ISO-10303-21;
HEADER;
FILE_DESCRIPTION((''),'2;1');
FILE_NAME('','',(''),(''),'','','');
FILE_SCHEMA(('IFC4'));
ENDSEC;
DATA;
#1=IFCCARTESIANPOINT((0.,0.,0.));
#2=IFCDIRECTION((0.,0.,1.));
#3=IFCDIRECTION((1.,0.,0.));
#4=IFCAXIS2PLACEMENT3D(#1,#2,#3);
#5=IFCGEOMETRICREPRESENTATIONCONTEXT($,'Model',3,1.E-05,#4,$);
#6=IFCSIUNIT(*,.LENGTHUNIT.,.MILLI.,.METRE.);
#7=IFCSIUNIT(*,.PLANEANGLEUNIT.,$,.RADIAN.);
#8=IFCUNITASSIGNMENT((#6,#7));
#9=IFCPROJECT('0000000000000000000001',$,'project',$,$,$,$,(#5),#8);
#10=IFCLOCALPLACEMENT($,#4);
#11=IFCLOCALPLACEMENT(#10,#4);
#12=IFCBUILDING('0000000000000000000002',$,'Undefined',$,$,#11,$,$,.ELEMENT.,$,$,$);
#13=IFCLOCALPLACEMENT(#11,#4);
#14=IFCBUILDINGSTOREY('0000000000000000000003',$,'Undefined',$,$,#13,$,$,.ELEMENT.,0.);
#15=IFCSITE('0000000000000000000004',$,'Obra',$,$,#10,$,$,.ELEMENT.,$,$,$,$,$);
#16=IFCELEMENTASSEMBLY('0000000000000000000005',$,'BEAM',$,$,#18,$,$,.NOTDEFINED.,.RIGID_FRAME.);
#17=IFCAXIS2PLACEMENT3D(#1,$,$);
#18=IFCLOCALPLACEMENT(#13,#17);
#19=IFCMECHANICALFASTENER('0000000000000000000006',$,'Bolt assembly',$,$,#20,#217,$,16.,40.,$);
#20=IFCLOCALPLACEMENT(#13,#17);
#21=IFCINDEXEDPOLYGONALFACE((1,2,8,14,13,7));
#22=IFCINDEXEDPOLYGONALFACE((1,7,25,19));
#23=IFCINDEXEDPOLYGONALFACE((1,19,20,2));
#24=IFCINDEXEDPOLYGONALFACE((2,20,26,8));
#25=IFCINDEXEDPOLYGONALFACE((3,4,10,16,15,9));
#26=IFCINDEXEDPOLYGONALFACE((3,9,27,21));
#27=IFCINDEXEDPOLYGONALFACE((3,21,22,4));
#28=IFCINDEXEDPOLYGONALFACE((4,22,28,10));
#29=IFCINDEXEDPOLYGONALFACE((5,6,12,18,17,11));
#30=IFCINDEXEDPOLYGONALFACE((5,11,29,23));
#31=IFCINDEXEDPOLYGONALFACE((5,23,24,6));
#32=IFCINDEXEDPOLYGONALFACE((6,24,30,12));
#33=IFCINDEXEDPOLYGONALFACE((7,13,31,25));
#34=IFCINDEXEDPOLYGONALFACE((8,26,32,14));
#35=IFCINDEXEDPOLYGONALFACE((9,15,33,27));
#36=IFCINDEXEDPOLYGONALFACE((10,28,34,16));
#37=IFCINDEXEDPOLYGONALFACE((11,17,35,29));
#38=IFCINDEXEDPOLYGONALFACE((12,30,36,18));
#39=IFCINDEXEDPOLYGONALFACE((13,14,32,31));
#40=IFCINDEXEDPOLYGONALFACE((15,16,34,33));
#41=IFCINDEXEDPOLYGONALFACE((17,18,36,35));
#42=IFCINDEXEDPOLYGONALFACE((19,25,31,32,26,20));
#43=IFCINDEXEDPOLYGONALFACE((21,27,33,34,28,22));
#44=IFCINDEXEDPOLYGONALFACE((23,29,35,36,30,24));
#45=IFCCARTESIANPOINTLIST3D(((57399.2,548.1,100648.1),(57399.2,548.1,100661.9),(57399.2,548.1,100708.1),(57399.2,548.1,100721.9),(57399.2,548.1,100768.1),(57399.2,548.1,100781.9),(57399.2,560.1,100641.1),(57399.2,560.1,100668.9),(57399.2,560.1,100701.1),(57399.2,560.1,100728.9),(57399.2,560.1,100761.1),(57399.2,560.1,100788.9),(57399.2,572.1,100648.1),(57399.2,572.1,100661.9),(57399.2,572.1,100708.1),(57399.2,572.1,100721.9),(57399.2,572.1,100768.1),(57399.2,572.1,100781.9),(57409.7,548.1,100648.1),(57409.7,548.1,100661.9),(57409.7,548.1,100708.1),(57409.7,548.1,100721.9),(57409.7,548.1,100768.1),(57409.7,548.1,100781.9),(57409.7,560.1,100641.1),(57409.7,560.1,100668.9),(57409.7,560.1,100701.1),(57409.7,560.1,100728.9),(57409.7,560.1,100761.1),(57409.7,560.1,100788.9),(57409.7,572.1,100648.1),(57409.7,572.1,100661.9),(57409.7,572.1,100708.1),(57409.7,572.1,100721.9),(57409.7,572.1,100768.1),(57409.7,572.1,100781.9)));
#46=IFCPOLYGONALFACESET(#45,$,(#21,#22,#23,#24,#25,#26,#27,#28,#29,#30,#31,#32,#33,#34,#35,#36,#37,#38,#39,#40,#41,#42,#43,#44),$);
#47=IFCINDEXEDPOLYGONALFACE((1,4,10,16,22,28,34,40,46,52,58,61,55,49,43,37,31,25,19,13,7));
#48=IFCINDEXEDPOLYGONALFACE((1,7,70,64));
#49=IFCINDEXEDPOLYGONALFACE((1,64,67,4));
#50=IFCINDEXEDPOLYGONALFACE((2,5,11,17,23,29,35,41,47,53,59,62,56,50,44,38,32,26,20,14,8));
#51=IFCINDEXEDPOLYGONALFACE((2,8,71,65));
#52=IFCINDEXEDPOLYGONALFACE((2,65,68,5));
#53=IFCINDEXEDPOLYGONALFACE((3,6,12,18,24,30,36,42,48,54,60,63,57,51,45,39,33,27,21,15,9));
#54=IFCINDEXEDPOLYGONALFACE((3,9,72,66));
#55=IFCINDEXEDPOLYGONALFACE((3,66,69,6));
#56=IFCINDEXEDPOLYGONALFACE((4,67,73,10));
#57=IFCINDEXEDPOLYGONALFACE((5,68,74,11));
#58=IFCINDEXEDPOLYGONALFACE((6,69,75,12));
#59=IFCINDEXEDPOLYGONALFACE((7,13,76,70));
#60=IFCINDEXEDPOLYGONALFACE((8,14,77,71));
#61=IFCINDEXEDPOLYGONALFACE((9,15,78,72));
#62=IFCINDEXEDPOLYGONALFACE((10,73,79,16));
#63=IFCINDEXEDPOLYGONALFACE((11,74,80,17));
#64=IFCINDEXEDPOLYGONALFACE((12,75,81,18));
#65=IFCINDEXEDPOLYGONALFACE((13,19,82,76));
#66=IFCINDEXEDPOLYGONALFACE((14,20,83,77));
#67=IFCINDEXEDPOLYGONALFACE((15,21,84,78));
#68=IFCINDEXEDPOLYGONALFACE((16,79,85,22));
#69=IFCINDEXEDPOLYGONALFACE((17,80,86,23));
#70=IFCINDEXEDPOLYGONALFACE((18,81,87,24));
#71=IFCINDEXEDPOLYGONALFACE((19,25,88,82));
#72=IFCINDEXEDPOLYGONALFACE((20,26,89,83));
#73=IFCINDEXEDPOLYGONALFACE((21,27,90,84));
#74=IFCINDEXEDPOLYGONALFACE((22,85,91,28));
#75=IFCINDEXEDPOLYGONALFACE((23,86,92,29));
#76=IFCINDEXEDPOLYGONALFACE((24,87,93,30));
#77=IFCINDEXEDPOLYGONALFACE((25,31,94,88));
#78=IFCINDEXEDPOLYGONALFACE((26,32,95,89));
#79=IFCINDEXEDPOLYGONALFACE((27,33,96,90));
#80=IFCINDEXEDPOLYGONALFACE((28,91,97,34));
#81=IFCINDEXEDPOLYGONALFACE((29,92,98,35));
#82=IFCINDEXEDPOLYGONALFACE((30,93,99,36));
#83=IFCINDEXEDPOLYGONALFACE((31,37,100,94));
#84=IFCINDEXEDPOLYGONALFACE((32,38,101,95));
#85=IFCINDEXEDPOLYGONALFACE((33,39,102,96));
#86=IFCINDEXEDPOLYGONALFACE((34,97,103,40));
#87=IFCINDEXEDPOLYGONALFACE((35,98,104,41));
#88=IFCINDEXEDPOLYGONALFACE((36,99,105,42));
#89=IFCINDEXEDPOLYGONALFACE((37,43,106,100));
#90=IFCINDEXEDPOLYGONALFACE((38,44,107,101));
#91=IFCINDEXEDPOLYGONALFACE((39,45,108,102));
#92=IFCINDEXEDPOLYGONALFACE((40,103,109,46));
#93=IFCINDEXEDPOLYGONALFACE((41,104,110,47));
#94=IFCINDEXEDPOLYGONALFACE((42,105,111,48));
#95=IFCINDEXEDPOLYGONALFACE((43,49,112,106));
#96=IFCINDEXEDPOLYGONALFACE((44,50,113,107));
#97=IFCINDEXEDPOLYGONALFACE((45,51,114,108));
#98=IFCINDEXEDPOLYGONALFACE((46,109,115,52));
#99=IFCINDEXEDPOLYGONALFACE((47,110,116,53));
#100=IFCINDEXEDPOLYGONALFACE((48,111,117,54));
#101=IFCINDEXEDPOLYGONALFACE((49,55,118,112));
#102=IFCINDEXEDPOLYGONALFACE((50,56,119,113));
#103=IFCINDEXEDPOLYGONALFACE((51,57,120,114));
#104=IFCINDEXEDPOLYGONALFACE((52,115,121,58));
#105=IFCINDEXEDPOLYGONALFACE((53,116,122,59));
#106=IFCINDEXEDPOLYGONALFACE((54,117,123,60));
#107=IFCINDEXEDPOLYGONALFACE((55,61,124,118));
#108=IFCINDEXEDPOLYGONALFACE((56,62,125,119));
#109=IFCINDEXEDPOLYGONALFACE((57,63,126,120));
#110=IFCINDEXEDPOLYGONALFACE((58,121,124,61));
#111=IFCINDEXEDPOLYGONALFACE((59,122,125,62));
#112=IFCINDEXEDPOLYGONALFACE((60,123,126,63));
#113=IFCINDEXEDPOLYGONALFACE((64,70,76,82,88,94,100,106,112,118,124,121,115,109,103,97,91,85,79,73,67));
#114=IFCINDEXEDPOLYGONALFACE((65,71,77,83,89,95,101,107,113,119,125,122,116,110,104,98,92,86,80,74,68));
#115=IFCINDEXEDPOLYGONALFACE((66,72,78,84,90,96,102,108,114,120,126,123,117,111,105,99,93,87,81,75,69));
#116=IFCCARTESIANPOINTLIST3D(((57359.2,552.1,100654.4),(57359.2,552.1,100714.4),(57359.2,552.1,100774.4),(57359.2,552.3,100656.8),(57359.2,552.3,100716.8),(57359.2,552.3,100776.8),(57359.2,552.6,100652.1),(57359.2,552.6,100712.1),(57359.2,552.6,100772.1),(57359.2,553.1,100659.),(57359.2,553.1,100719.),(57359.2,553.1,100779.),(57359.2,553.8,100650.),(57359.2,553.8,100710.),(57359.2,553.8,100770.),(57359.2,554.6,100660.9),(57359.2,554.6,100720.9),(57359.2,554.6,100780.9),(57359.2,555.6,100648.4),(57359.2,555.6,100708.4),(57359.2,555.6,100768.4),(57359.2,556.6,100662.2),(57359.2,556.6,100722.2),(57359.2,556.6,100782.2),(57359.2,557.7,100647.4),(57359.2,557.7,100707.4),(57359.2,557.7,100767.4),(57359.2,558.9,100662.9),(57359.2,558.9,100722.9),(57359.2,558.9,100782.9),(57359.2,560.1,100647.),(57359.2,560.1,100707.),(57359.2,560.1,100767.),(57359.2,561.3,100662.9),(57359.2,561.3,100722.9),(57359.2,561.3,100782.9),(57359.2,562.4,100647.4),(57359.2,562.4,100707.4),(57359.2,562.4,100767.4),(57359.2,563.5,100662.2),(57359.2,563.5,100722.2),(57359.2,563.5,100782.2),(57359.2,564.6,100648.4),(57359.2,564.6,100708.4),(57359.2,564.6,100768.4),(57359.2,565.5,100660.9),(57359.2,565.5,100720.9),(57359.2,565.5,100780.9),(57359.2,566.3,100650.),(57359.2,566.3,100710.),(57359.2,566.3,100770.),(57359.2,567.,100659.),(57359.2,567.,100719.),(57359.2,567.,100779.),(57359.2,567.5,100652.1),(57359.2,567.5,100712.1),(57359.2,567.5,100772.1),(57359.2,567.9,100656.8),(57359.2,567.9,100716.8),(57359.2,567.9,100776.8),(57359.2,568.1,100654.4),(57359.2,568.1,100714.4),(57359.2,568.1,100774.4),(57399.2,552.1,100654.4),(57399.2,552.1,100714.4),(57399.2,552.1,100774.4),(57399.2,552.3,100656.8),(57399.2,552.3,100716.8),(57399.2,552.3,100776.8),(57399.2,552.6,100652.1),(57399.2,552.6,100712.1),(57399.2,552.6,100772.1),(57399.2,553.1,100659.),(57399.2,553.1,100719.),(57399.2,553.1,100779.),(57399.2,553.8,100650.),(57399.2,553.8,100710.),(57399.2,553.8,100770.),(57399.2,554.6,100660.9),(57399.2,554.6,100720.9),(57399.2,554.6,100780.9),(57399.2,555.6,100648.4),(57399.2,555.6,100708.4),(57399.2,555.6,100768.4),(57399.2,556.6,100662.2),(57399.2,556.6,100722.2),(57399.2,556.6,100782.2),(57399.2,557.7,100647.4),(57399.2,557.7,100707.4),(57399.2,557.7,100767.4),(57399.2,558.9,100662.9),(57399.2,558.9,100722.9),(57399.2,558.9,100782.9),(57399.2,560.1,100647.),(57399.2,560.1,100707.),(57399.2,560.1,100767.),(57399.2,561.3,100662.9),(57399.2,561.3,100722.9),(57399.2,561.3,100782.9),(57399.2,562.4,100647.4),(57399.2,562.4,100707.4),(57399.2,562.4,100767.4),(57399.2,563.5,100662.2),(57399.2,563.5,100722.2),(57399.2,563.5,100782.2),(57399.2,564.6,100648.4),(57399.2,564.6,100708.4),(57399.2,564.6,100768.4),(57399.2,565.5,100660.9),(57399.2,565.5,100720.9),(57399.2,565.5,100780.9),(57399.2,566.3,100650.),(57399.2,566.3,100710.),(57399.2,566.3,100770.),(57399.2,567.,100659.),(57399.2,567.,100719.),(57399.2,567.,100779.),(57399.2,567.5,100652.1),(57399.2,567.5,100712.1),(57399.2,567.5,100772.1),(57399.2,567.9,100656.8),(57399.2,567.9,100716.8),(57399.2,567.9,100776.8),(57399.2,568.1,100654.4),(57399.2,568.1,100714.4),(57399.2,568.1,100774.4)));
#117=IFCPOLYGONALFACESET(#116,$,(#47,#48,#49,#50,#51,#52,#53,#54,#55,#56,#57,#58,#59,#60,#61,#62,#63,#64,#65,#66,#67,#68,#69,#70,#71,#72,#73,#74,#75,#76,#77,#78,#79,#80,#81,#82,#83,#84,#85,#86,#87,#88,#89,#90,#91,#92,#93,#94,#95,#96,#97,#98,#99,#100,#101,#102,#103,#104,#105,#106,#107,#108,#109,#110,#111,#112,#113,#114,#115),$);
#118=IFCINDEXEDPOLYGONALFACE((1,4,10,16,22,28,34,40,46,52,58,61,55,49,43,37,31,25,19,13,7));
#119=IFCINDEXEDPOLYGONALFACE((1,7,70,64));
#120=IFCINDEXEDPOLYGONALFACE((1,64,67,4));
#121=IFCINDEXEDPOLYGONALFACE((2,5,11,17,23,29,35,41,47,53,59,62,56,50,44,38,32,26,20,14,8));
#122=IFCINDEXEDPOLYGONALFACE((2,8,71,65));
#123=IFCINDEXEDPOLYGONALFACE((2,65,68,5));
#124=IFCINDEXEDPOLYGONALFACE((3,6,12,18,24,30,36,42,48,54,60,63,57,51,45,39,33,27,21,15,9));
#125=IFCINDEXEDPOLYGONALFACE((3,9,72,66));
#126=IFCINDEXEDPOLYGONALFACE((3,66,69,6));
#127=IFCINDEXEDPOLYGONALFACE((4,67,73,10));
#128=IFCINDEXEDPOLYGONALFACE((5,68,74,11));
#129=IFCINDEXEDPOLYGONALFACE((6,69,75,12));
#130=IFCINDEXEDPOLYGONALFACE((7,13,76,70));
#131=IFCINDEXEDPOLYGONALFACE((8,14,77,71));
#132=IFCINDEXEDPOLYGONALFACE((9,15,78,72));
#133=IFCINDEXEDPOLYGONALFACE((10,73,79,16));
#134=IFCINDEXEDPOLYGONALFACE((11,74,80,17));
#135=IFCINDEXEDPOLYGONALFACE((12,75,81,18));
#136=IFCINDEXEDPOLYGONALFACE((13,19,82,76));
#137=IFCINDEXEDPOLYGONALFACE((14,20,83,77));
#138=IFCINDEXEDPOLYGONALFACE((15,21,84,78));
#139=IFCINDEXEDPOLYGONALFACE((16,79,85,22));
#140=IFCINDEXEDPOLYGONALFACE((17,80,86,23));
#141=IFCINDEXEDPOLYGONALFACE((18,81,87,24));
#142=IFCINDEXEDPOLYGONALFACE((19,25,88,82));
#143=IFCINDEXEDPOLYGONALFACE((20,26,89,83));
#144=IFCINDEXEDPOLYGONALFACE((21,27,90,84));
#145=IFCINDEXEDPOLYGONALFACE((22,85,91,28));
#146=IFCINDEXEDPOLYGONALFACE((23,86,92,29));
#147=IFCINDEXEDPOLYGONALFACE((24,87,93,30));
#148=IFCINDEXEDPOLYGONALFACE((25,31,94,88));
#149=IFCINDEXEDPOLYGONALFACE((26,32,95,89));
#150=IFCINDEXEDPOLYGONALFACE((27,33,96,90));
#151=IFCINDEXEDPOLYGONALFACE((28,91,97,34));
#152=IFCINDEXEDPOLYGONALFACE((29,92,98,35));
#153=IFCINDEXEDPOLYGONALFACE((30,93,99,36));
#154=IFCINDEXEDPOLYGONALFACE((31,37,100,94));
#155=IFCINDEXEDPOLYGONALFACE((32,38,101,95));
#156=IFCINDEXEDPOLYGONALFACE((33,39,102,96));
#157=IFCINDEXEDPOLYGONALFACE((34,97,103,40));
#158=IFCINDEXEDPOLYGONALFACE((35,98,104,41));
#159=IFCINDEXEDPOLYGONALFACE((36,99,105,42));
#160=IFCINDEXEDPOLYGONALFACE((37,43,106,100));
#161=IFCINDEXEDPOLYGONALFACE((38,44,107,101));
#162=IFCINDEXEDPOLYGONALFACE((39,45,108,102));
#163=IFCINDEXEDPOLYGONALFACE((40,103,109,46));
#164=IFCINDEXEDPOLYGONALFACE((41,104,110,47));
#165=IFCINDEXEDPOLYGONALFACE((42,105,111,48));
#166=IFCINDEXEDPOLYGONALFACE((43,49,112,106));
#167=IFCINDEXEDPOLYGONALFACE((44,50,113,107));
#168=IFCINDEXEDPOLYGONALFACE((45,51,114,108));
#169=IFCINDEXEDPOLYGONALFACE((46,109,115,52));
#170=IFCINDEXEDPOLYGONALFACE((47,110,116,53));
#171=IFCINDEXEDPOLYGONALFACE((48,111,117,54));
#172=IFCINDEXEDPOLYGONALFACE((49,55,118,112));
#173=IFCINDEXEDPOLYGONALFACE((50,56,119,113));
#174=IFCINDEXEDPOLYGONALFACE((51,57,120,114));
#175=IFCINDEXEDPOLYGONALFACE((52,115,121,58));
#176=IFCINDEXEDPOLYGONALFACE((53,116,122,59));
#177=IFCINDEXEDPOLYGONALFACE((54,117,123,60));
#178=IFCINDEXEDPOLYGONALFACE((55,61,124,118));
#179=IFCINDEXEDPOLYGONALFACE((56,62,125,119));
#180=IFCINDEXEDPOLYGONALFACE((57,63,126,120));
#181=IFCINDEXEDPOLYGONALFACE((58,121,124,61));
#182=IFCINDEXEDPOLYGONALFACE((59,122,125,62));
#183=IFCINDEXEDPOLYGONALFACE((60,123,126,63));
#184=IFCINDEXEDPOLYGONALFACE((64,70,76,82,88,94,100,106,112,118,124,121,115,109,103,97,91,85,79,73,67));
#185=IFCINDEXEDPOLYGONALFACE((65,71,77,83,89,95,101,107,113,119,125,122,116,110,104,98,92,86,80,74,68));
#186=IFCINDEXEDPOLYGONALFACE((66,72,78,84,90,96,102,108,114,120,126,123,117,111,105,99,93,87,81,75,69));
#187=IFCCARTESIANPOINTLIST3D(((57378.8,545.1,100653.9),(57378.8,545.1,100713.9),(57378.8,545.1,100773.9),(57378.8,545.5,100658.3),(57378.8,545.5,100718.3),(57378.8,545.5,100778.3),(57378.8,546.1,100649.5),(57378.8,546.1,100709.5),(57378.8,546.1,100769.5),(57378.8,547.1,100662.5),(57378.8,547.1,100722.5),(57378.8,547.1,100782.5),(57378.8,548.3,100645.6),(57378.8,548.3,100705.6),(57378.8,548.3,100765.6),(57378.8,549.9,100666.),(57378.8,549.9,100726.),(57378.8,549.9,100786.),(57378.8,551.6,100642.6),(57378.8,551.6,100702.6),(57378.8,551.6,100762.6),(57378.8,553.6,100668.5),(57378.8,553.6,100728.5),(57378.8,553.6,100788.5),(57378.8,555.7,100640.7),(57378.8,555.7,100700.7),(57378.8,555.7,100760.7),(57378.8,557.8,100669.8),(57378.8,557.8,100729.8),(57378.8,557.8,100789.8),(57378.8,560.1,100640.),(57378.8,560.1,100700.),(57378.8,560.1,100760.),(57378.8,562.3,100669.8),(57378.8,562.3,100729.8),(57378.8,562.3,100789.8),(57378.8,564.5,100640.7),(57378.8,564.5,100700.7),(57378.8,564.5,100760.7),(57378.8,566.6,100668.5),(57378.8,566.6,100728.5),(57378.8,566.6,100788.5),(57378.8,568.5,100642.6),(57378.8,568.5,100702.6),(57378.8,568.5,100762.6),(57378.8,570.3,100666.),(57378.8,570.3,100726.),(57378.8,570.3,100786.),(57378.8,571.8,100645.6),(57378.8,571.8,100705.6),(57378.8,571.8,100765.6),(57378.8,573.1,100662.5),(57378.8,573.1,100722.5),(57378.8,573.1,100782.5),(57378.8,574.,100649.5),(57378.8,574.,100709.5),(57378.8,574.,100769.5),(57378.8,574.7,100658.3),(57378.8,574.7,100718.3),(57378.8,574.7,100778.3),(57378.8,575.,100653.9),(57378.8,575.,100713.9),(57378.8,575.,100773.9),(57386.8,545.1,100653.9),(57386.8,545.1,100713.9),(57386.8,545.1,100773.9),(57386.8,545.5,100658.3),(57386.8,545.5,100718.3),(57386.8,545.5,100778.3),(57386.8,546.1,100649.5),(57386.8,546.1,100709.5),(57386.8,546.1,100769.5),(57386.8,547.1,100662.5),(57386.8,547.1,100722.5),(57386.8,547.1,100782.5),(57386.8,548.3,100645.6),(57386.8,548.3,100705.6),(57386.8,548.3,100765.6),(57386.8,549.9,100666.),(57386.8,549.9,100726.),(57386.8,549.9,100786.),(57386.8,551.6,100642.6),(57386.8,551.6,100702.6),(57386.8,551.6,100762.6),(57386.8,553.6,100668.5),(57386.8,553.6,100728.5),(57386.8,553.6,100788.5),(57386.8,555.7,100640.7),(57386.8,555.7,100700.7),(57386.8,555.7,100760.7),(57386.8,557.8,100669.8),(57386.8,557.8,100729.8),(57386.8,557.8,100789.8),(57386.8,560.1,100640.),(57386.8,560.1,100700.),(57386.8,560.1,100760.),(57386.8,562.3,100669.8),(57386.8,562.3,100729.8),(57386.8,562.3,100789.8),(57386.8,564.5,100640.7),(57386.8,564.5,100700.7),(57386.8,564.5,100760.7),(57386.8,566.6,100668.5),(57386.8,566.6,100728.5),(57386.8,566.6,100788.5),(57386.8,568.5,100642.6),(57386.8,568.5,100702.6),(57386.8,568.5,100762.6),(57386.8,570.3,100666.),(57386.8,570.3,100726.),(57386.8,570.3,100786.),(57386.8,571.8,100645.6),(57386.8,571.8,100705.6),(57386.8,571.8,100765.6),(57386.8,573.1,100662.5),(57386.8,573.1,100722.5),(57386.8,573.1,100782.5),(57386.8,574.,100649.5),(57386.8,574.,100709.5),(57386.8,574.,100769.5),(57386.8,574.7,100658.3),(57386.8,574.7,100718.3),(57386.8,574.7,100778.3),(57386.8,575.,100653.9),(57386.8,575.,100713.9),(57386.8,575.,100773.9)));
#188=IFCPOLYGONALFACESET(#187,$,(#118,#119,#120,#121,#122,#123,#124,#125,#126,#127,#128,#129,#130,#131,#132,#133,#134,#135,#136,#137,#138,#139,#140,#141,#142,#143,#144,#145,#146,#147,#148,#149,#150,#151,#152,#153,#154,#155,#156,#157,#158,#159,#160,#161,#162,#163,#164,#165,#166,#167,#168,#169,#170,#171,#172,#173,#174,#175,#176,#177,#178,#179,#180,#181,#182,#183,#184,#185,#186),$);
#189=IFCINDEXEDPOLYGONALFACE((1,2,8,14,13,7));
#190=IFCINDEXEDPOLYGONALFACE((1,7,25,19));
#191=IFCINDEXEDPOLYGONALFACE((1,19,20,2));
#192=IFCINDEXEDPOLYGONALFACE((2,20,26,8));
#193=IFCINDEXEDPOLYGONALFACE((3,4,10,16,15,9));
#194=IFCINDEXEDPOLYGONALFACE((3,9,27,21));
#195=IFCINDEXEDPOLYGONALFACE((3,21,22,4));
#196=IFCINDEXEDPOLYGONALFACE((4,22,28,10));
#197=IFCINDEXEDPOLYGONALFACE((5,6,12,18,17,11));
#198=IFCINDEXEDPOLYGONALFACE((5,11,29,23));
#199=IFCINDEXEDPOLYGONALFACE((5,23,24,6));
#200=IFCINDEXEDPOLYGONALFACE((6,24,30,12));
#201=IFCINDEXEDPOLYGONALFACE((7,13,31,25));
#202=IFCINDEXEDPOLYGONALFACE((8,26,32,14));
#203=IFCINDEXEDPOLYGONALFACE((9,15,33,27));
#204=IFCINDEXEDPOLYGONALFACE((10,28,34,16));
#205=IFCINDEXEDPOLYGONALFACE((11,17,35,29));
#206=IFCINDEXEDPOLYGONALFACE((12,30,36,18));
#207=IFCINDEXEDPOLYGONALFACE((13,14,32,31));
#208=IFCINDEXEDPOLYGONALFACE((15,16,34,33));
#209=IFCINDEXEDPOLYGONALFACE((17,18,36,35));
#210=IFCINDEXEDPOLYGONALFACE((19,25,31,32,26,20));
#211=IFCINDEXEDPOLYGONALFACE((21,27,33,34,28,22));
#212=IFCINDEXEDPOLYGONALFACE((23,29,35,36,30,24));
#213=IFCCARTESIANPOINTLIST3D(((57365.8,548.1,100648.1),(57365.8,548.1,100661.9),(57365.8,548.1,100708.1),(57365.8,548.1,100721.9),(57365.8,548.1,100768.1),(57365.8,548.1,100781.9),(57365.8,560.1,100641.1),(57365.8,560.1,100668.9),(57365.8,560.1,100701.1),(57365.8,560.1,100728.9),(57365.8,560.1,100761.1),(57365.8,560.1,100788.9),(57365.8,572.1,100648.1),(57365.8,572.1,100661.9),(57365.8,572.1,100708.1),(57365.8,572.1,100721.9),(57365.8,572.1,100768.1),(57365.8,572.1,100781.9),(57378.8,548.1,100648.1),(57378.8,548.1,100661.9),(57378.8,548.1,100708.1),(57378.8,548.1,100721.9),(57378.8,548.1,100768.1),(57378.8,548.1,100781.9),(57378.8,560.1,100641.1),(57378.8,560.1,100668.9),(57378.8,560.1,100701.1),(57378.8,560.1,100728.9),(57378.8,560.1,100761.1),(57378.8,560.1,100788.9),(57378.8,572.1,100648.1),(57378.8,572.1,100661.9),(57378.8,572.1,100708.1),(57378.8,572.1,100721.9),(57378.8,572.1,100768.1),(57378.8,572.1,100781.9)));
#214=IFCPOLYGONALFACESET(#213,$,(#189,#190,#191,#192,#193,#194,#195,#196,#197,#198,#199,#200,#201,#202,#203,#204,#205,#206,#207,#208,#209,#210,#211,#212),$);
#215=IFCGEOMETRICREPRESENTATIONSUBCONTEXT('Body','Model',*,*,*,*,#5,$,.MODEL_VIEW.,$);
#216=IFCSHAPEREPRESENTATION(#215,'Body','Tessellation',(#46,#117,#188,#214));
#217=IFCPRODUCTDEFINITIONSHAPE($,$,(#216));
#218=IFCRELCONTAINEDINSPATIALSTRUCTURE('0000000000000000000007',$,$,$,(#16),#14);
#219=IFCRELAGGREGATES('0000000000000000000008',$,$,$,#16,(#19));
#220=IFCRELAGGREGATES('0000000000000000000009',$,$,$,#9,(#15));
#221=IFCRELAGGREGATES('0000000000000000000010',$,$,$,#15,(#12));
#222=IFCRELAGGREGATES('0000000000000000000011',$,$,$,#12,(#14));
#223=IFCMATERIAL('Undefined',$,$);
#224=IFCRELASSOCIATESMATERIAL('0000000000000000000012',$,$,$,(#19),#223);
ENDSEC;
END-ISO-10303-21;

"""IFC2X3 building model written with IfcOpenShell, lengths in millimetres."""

from ifc_helpers import new_model, si_unit, frame, origin_with_axes, origin_2d_with_axis, place, context, subcontext, project, spatial, polyline, circle, outline, extrude, source, transform, mapped, material, element, aggregate, save


model = new_model("IFC2X3")

# Units and contexts
model_context = context("Model", 3, precision=1e-05, world=origin_with_axes())
body_context = subcontext(model_context, "Body", "Model", "MODEL_VIEW")
ifc_project = project(units=[si_unit("LENGTHUNIT", "METRE", prefix="MILLI"), si_unit("PLANEANGLEUNIT", "RADIAN")], contexts=[model_context])

# Site, building, storey
site_placement = place(None, origin_with_axes())
site = spatial("IfcSite", under=ifc_project, at=site_placement, Name="Obra", CompositionType="ELEMENT")
building_placement = place(site_placement, origin_with_axes())
building = spatial("IfcBuilding", under=site, at=building_placement, Name="Undefined", CompositionType="ELEMENT")
storey_placement = place(building_placement, origin_with_axes())
storey = spatial("IfcBuildingStorey", under=building, at=storey_placement, Name="Undefined", CompositionType="ELEMENT", Elevation=0.0)

# Shared definitions
ifc_material_1 = material(Name="Undefined")

# Element assembly, mechanical fastener
shared_shape_1 = source(origin_with_axes(), body_context, "Body", "SweptSolid", [
    extrude(outline(polyline([(13.9, 0.0), (6.9, 12.0), (-6.9, 12.0), (-13.9, 0.0), (-6.9, -12.0), (6.9, -12.0), (13.9, 0.0)])), frame((0.0, -19.7, 0.0), z_axis=(0.0, 1.0, 0.0), x_axis=(1.0, 0.0, 0.0)), (0.0, 0.0, 1.0), 10.6),
    extrude(circle(Radius=8.0, at=origin_2d_with_axis()), frame((0.0, -9.1, 0.0), z_axis=(0.0, 1.0, 0.0), x_axis=(1.0, 0.0, 0.0)), (0.0, 0.0, 1.0), 40.0),
    extrude(circle(Radius=15.0, at=origin_2d_with_axis()), frame((0.0, 3.3, 0.0), z_axis=(0.0, 1.0, 0.0), x_axis=(1.0, 0.0, 0.0)), (0.0, 0.0, 1.0), 8.0),
    extrude(outline(polyline([(13.9, 0.0), (6.9, 12.0), (-6.9, 12.0), (-13.9, 0.0), (-6.9, -12.0), (6.9, -12.0), (13.9, 0.0)])), frame((0.0, 11.3, 0.0), z_axis=(0.0, 1.0, 0.0), x_axis=(1.0, 0.0, 0.0)), (0.0, 0.0, 1.0), 13.0),
])
assembly_1_placement = place(storey_placement, origin_with_axes())
assembly_1 = element("IfcElementAssembly", 1, at=assembly_1_placement, inside=storey, Name="BEAM", AssemblyPlace="NOTDEFINED", PredefinedType="RIGID_FRAME")
mechanical_fastener_1_placement = place(assembly_1_placement, frame((57390.1, 510.1, 100835.0), z_axis=(-0.000002, 1.0, 0.0), x_axis=(0.0, 0.0, -1.0)))
mechanical_fastener_1 = element("IfcMechanicalFastener", 2, at=mechanical_fastener_1_placement, material=ifc_material_1, Name="Bolt assembly", NominalDiameter=16.0, NominalLength=40.0, context=body_context, shape_type="MappedRepresentation", body=[
    mapped(shared_shape_1, transform((60.0, 0.0, 50.0))),
    mapped(shared_shape_1, transform((120.0, 0.0, 50.0))),
    mapped(shared_shape_1, transform((180.0, 0.0, 50.0))),
])

aggregate(assembly_1, [mechanical_fastener_1])

save(model, "model.ifc")
